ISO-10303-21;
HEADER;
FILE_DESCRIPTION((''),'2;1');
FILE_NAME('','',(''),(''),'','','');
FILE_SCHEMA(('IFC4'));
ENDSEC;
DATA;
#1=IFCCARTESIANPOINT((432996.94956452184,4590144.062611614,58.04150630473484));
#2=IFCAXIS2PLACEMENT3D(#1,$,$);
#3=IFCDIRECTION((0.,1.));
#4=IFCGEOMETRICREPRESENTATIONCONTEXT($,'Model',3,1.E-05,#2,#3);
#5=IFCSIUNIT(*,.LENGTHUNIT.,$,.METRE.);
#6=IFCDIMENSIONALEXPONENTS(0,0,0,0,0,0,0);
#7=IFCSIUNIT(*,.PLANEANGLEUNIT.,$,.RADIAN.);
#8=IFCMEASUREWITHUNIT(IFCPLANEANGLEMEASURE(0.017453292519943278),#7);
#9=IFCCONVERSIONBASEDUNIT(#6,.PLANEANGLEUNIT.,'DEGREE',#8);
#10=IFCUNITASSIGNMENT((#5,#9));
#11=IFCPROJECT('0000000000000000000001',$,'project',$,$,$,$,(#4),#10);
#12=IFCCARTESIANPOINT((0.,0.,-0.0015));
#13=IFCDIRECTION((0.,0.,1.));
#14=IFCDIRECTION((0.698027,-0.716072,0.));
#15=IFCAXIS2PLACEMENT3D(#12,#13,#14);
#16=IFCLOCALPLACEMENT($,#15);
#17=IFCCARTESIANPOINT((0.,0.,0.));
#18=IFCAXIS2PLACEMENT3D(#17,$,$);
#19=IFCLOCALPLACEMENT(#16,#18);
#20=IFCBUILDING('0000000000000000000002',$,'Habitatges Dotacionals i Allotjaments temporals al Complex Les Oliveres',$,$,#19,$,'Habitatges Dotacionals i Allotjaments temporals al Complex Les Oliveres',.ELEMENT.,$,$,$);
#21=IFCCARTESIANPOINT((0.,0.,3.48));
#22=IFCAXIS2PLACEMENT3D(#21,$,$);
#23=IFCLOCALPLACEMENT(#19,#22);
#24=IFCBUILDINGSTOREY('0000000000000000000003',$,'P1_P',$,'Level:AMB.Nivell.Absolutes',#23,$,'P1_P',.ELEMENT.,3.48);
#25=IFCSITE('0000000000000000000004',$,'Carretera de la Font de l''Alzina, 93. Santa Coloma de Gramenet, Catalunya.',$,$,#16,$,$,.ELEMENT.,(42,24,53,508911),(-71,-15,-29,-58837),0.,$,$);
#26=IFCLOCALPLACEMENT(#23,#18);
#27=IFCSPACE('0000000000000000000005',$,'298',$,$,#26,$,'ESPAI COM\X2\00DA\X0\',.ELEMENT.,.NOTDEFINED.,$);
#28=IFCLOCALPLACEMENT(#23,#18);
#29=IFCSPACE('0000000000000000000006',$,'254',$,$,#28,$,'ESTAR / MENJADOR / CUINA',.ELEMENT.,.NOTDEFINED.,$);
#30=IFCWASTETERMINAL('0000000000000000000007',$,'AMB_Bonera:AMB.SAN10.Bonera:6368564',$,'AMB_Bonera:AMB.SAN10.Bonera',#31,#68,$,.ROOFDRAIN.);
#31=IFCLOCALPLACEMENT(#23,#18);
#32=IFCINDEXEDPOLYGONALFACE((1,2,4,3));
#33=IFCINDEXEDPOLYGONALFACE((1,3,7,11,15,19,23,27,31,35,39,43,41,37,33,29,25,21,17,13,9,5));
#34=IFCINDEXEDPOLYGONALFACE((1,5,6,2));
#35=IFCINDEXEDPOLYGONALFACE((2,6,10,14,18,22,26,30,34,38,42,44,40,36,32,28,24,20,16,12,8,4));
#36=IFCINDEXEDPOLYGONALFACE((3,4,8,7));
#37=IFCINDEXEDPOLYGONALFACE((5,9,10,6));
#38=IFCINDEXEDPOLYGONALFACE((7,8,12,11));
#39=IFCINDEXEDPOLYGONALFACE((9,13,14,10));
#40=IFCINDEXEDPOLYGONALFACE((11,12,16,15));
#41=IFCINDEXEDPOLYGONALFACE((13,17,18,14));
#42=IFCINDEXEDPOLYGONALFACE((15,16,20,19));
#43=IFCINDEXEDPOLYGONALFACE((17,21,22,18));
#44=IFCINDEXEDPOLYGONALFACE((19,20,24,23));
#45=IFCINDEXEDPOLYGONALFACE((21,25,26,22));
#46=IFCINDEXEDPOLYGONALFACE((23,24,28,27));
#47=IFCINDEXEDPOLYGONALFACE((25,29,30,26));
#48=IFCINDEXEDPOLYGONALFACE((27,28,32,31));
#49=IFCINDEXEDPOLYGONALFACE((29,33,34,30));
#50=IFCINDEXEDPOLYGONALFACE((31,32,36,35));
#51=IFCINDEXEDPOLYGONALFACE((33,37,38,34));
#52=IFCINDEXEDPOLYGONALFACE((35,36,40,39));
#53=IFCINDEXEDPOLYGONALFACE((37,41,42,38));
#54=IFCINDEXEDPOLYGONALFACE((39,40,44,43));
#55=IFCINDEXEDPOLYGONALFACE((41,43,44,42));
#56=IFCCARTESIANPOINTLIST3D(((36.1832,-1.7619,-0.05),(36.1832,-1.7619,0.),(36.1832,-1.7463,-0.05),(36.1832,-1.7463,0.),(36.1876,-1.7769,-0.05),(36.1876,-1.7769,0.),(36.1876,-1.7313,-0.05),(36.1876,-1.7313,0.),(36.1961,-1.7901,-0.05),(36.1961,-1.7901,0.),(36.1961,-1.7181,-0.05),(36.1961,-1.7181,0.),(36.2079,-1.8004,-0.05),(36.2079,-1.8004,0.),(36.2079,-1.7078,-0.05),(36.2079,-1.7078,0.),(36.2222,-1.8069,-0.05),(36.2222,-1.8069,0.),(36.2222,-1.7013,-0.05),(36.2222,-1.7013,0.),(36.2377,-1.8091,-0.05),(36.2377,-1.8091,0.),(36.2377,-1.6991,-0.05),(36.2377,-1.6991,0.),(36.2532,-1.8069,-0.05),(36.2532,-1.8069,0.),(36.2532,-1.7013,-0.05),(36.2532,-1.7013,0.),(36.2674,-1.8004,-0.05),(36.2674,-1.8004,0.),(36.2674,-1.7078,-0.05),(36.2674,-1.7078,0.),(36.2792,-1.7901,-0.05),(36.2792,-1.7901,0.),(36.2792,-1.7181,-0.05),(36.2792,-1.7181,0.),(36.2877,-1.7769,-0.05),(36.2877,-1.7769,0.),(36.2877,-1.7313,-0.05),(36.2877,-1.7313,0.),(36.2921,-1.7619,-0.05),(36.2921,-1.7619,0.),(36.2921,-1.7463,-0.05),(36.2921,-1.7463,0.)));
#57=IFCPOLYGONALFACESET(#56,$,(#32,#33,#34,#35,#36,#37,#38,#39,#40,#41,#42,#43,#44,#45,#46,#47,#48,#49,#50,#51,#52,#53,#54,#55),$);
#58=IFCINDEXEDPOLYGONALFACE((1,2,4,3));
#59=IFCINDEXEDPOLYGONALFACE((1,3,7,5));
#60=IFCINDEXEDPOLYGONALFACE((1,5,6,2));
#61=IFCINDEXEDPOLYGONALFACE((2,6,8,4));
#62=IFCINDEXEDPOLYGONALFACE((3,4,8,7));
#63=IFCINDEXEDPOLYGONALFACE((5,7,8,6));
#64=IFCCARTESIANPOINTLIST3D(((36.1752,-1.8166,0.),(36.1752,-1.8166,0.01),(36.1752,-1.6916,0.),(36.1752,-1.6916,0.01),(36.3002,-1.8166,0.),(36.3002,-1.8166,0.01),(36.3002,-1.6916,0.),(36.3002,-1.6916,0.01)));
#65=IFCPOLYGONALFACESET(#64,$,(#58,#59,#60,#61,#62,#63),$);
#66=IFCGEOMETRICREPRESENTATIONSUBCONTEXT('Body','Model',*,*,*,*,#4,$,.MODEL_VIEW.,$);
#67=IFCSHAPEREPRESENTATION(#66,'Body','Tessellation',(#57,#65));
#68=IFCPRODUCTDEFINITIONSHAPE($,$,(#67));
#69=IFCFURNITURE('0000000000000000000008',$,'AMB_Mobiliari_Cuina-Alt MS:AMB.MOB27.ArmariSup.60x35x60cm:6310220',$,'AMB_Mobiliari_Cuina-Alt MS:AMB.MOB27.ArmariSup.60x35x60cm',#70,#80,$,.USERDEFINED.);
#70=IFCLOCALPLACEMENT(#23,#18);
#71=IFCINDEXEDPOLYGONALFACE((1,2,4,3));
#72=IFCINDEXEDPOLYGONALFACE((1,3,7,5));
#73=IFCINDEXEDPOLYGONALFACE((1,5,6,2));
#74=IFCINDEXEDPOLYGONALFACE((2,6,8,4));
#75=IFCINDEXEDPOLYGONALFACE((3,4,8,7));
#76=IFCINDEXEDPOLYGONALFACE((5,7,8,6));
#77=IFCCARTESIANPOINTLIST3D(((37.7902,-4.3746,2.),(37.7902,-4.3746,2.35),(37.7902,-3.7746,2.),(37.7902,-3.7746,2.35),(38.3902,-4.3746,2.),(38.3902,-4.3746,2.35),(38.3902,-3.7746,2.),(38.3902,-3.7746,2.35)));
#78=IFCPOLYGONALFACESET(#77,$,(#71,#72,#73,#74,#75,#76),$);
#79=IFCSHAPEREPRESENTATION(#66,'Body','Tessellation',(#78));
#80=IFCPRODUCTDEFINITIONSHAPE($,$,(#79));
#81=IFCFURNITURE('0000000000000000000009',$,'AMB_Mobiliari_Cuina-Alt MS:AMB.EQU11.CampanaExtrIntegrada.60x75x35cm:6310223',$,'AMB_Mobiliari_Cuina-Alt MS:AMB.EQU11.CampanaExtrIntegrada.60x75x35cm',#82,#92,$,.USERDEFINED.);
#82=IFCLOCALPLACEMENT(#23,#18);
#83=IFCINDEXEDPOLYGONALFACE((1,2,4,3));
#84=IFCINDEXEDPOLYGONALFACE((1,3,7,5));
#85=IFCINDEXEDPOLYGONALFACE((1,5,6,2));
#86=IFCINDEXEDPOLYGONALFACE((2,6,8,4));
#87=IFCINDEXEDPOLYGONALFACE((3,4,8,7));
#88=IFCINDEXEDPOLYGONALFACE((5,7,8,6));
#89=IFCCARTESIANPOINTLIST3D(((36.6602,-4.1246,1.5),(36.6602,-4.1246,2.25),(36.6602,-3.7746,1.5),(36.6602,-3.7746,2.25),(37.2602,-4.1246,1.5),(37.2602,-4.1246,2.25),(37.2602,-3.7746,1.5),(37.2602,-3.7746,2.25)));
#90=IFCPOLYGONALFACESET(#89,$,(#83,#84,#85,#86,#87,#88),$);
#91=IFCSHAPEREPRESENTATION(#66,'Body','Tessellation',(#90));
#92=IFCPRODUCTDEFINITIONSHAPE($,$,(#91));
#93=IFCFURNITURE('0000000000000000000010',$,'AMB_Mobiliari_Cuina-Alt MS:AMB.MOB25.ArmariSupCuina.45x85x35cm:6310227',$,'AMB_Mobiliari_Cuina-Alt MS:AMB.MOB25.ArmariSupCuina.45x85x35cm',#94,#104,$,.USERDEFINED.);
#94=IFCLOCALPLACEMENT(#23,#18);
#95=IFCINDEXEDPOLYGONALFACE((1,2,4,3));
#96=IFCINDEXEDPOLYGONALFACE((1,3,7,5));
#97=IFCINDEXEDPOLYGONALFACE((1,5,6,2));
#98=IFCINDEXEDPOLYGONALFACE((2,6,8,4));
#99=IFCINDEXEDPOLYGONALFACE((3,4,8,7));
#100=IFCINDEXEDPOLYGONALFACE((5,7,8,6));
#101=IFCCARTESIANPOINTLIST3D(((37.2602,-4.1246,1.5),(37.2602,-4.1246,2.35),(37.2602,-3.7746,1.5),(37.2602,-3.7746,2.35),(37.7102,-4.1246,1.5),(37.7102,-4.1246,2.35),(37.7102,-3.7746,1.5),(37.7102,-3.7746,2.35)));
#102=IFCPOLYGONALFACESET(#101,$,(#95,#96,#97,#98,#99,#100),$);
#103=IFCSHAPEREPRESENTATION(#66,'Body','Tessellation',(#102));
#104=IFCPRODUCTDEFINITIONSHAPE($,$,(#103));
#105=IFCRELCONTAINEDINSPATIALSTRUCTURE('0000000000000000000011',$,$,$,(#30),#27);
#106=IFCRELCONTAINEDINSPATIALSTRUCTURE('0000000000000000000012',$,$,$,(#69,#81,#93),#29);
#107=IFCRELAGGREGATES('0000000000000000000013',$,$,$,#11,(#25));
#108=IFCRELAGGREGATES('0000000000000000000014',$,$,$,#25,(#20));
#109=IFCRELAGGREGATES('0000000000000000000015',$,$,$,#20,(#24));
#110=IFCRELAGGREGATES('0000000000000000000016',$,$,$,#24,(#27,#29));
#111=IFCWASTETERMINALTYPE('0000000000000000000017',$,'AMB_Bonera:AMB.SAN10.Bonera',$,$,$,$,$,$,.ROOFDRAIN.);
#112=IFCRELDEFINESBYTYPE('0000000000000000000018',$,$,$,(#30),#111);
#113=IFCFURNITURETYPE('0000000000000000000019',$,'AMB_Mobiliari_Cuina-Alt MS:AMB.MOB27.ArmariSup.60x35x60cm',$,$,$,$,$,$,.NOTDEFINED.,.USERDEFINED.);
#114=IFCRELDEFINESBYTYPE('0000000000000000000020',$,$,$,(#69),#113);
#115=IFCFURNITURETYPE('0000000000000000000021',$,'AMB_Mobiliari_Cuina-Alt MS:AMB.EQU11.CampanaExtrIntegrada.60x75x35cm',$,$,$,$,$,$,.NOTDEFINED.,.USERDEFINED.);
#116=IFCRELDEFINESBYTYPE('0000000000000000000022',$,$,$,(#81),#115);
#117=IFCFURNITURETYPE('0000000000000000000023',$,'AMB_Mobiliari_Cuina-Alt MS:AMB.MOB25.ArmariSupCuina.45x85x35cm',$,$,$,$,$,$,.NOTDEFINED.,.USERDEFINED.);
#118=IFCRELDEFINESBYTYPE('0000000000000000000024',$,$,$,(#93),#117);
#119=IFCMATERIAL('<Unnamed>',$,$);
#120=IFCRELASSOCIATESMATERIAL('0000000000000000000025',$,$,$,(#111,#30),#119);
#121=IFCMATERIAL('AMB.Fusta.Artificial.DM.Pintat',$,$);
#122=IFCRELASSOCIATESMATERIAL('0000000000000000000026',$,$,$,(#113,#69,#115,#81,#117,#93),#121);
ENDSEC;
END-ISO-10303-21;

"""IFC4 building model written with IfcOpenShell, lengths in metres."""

from ifc_helpers import new_model, entity, si_unit, converted_unit, direction, frame, origin, place, context, subcontext, project, spatial, arc, indexed_curve, outline, extrude, source, transform, mapped, material, type_object, type_shapes, element, save


model = new_model("IFC4")

# Units and contexts
model_context = context("Model", 3, precision=1e-05, world=frame((432996.94956452184, 4590144.062611614, 58.04150630473484)), true_north=direction((0.0, 1.0)))
body_context = subcontext(model_context, "Body", "Model", "MODEL_VIEW")
ifc_project = project(units=[si_unit("LENGTHUNIT", "METRE"), converted_unit("PLANEANGLEUNIT", "DEGREE", entity("IfcPlaneAngleMeasure", 0.017453292519943278), si_unit("PLANEANGLEUNIT", "RADIAN"), dimensions=[0, 0, 0, 0, 0, 0, 0])], contexts=[model_context])

# Site, building, storey
site_placement = place(None, frame((0.0, 0.0, -0.0015), z_axis=(0.0, 0.0, 1.0), x_axis=(0.698027, -0.716072, 0.0)))
site = spatial("IfcSite", under=ifc_project, at=site_placement, Name="Carretera de la Font de l'Alzina, 93. Santa Coloma de Gramenet, Catalunya.", CompositionType="ELEMENT", RefLatitude=(42, 24, 53, 508911), RefLongitude=(-71, -15, -29, -58837), RefElevation=0.0)
building_placement = place(site_placement, origin())
building = spatial("IfcBuilding", under=site, at=building_placement, Name="Habitatges Dotacionals i Allotjaments temporals al Complex Les Oliveres", LongName="Habitatges Dotacionals i Allotjaments temporals al Complex Les Oliveres", CompositionType="ELEMENT")
storey_placement = place(building_placement, frame((0.0, 0.0, 3.48)))
storey = spatial("IfcBuildingStorey", under=building, at=storey_placement, Name="P1_P", ObjectType="Level:AMB.Nivell.Absolutes", LongName="P1_P", CompositionType="ELEMENT", Elevation=3.48)

# Shared definitions
ifc_material_1 = material(Name="AMB.Fusta.Artificial.DM.Pintat")

# Shared definitions
ifc_material_2 = material(Name="<Unnamed>")

# Shared definitions
space_1_placement = place(storey_placement, origin())
space_1 = spatial("IfcSpace", under=storey, at=space_1_placement, Name="298", LongName="ESPAI COMÚ", CompositionType="ELEMENT", PredefinedType="NOTDEFINED")

# Waste terminal
waste_terminal_type = type_object("IfcWasteTerminalType", Name="AMB_Bonera:AMB.SAN10.Bonera", PredefinedType="ROOFDRAIN", material=ifc_material_2)
shared_shape_1 = source(origin(), body_context, "Body", "SweptSolid", [
    extrude(outline(indexed_curve([(-0.055, 0.0), (0.0, -0.055), (0.055, 0.0), (0.0, 0.055)], segments=[arc(1, 2, 3), arc(3, 4, 1)], self_intersect=False)), frame((0.0, 0.0, -0.05), z_axis=(0.0, 0.0, 1.0), x_axis=(0.0, -1.0, 0.0)), (0.0, 0.0, 1.0), 0.05),
    extrude(outline(indexed_curve([(-0.0625, -0.0625), (0.0625, -0.0625), (0.0625, 0.0625), (-0.0625, 0.0625), (-0.0625, -0.0625)], self_intersect=False)), frame((0.0, 0.0, 0.0), z_axis=(0.0, 0.0, 1.0), x_axis=(-1.0, 0.0, 0.0)), (0.0, 0.0, 1.0), 0.01),
])
type_shapes(waste_terminal_type, [shared_shape_1])
waste_terminal_placement = place(space_1_placement, frame((36.2377, -1.7541, 0.0)))
element("IfcWasteTerminal", 1, at=waste_terminal_placement, inside=space_1, type_object=waste_terminal_type, material=ifc_material_2, Name="AMB_Bonera:AMB.SAN10.Bonera:6368564", ObjectType="AMB_Bonera:AMB.SAN10.Bonera", PredefinedType="ROOFDRAIN", context=body_context, shape_type="MappedRepresentation", body=[
    mapped(shared_shape_1, transform((0.0, 0.0, 0.0), scale=1.0)),
])

# Shared definitions
space_2_placement = place(storey_placement, origin())
space_2 = spatial("IfcSpace", under=storey, at=space_2_placement, Name="254", LongName="ESTAR / MENJADOR / CUINA", CompositionType="ELEMENT", PredefinedType="NOTDEFINED")

# Furniture
furniture_type_1 = type_object("IfcFurnitureType", Name="AMB_Mobiliari_Cuina-Alt MS:AMB.MOB27.ArmariSup.60x35x60cm", AssemblyPlace="NOTDEFINED", PredefinedType="USERDEFINED", material=ifc_material_1)
shared_shape_2 = source(origin(), body_context, "Body", "SweptSolid", [
    extrude(outline(indexed_curve([(-0.3, -0.3), (0.3, -0.3), (0.3, 0.3), (-0.3, 0.3), (-0.3, -0.3)], self_intersect=False)), frame((-0.5175, -0.3, 0.0), z_axis=(0.0, 0.0, 1.0), x_axis=(-1.0, 0.0, 0.0)), (0.0, 0.0, 1.0), 0.35),
])
type_shapes(furniture_type_1, [shared_shape_2])
furniture_1_placement = place(space_2_placement, frame((38.6077, -3.7746, 2.0)))
element("IfcFurniture", 2, at=furniture_1_placement, inside=space_2, type_object=furniture_type_1, material=ifc_material_1, Name="AMB_Mobiliari_Cuina-Alt MS:AMB.MOB27.ArmariSup.60x35x60cm:6310220", ObjectType="AMB_Mobiliari_Cuina-Alt MS:AMB.MOB27.ArmariSup.60x35x60cm", PredefinedType="USERDEFINED", context=body_context, shape_type="MappedRepresentation", body=[
    mapped(shared_shape_2, transform((0.0, 0.0, 0.0), scale=1.0)),
])
furniture_type_2 = type_object("IfcFurnitureType", Name="AMB_Mobiliari_Cuina-Alt MS:AMB.EQU11.CampanaExtrIntegrada.60x75x35cm", AssemblyPlace="NOTDEFINED", PredefinedType="USERDEFINED", material=ifc_material_1)
shared_shape_3 = source(origin(), body_context, "Body", "SweptSolid", [
    extrude(outline(indexed_curve([(-0.3, -0.175), (0.3, -0.175), (0.3, 0.175), (-0.3, 0.175), (-0.3, -0.175)], self_intersect=False)), frame((-0.5175, -0.175, 0.0), z_axis=(0.0, 0.0, 1.0), x_axis=(-1.0, 0.0, 0.0)), (0.0, 0.0, 1.0), 0.75),
])
type_shapes(furniture_type_2, [shared_shape_3])
furniture_2_placement = place(space_2_placement, frame((37.4777, -3.7746, 1.5)))
element("IfcFurniture", 3, at=furniture_2_placement, inside=space_2, type_object=furniture_type_2, material=ifc_material_1, Name="AMB_Mobiliari_Cuina-Alt MS:AMB.EQU11.CampanaExtrIntegrada.60x75x35cm:6310223", ObjectType="AMB_Mobiliari_Cuina-Alt MS:AMB.EQU11.CampanaExtrIntegrada.60x75x35cm", PredefinedType="USERDEFINED", context=body_context, shape_type="MappedRepresentation", body=[
    mapped(shared_shape_3, transform((0.0, 0.0, 0.0), scale=1.0)),
])
furniture_type_3 = type_object("IfcFurnitureType", Name="AMB_Mobiliari_Cuina-Alt MS:AMB.MOB25.ArmariSupCuina.45x85x35cm", AssemblyPlace="NOTDEFINED", PredefinedType="USERDEFINED", material=ifc_material_1)
shared_shape_4 = source(origin(), body_context, "Body", "SweptSolid", [
    extrude(outline(indexed_curve([(-0.225, -0.175), (0.225, -0.175), (0.225, 0.175), (-0.225, 0.175), (-0.225, -0.175)], self_intersect=False)), frame((-0.5925, -0.175, 0.0), z_axis=(0.0, 0.0, 1.0), x_axis=(-1.0, 0.0, 0.0)), (0.0, 0.0, 1.0), 0.85),
])
type_shapes(furniture_type_3, [shared_shape_4])
furniture_3_placement = place(space_2_placement, frame((38.0777, -3.7746, 1.5)))
element("IfcFurniture", 4, at=furniture_3_placement, inside=space_2, type_object=furniture_type_3, material=ifc_material_1, Name="AMB_Mobiliari_Cuina-Alt MS:AMB.MOB25.ArmariSupCuina.45x85x35cm:6310227", ObjectType="AMB_Mobiliari_Cuina-Alt MS:AMB.MOB25.ArmariSupCuina.45x85x35cm", PredefinedType="USERDEFINED", context=body_context, shape_type="MappedRepresentation", body=[
    mapped(shared_shape_4, transform((0.0, 0.0, 0.0), scale=1.0)),
])

save(model, "model.ifc")
